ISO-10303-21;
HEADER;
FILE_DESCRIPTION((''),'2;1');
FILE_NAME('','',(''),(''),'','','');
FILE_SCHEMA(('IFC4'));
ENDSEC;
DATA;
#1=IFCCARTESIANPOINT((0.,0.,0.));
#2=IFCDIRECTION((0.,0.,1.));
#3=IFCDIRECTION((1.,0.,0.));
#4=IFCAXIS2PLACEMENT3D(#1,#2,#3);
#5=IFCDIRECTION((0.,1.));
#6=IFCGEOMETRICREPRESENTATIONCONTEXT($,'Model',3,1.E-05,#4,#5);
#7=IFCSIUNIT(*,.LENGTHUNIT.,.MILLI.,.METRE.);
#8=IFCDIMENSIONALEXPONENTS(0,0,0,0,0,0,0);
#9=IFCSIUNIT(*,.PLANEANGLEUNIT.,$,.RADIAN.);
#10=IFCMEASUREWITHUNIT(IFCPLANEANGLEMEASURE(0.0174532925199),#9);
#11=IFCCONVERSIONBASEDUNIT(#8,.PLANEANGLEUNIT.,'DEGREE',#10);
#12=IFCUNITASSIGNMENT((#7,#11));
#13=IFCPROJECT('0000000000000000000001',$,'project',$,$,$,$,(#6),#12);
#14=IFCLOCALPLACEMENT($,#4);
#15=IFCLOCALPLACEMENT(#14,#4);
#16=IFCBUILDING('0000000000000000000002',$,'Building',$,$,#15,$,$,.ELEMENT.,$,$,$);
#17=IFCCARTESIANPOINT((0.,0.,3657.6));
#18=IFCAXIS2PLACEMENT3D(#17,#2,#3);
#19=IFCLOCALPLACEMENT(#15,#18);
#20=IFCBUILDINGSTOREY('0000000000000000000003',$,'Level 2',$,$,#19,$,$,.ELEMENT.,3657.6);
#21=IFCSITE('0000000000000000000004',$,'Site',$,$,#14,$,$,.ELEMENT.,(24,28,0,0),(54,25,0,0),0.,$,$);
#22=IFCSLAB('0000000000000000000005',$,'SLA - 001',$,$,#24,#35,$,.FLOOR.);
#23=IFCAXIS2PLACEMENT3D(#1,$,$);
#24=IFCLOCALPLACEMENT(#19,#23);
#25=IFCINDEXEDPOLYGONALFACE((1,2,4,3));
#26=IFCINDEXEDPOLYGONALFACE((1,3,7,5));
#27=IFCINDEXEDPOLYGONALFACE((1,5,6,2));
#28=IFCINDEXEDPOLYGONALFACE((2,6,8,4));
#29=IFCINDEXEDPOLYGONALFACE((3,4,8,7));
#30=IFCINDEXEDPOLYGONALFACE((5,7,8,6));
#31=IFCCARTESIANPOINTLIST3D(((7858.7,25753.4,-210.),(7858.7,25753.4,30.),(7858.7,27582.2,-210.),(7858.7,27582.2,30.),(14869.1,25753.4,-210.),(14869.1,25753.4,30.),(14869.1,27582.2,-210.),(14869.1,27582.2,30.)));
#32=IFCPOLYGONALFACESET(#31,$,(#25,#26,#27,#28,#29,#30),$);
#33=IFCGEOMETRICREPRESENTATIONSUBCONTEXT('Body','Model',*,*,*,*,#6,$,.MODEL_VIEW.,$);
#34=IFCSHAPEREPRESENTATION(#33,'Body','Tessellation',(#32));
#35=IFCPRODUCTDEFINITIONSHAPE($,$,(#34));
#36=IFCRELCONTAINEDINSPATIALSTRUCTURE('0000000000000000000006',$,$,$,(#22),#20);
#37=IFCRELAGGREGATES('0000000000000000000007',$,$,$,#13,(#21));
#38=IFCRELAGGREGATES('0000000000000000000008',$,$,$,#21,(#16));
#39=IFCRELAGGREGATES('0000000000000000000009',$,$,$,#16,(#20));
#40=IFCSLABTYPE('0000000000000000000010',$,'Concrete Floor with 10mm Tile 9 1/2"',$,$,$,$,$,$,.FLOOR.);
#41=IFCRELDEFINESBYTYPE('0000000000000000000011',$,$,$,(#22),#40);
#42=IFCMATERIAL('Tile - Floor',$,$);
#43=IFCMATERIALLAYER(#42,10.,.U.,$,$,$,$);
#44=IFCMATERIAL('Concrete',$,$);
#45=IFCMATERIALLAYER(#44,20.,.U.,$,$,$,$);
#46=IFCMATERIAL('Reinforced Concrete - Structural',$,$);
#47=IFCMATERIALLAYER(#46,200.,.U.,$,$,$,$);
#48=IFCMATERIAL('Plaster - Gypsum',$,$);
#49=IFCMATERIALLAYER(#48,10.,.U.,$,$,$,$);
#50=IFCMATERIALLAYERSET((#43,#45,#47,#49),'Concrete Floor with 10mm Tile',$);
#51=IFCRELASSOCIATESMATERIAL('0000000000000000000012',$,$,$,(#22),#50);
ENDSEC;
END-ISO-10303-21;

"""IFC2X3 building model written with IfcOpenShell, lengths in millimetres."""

from ifc_helpers import new_model, entity, si_unit, converted_unit, direction, frame, origin_with_axes, place, context, subcontext, project, spatial, polyline, outline, extrude, material, layer, layer_set, layer_usage, type_object, element, save


model = new_model("IFC2X3")

# Units and contexts
model_context = context("Model", 3, precision=1e-05, world=origin_with_axes(), true_north=direction((0.0, 1.0)))
body_context = subcontext(model_context, "Body", "Model", "MODEL_VIEW")
ifc_project = project(units=[si_unit("LENGTHUNIT", "METRE", prefix="MILLI"), converted_unit("PLANEANGLEUNIT", "DEGREE", entity("IfcPlaneAngleMeasure", 0.0174532925199), si_unit("PLANEANGLEUNIT", "RADIAN"), dimensions=[0, 0, 0, 0, 0, 0, 0])], contexts=[model_context])

# Site, building, storey
site_placement = place(None, origin_with_axes())
site = spatial("IfcSite", under=ifc_project, at=site_placement, Name="Site", CompositionType="ELEMENT", RefLatitude=(24, 28, 0, 0), RefLongitude=(54, 25, 0, 0), RefElevation=0.0)
building_placement = place(site_placement, origin_with_axes())
building = spatial("IfcBuilding", under=site, at=building_placement, Name="Building", CompositionType="ELEMENT")
storey_placement = place(building_placement, frame((0.0, 0.0, 3657.6), z_axis=(0.0, 0.0, 1.0), x_axis=(1.0, 0.0, 0.0)))
storey = spatial("IfcBuildingStorey", under=building, at=storey_placement, Name="Level 2", CompositionType="ELEMENT", Elevation=3657.6)

# Slab
ifc_material_1 = material(Name="Tile - Floor")
ifc_layer_1 = layer(ifc_material_1, 10.0, ventilated="UNKNOWN")
ifc_material_2 = material(Name="Concrete")
ifc_layer_2 = layer(ifc_material_2, 20.0, ventilated="UNKNOWN")
ifc_material_3 = material(Name="Reinforced Concrete - Structural")
ifc_layer_3 = layer(ifc_material_3, 200.0, ventilated="UNKNOWN")
ifc_material_4 = material(Name="Plaster - Gypsum")
ifc_layer_4 = layer(ifc_material_4, 10.0, ventilated="UNKNOWN")
ifc_layer_set = layer_set([ifc_layer_1, ifc_layer_2, ifc_layer_3, ifc_layer_4], Name="Concrete Floor with 10mm Tile")
ifc_layer_usage = layer_usage(ifc_layer_set, "AXIS3", "NEGATIVE", 240.0)
slab_type = type_object("IfcSlabType", Name="Concrete Floor with 10mm Tile 9 1/2\"", PredefinedType="FLOOR")
slab_placement = place(storey_placement, frame((14869.1, 27582.2, 0.0), z_axis=(0.0, 0.0, 1.0), x_axis=(1.0, 0.0, 0.0)))
element("IfcSlab", 1, at=slab_placement, inside=storey, type_object=slab_type, material=ifc_layer_usage, Name="SLA - 001", PredefinedType="FLOOR", context=body_context, shape_type="SweptSolid", body=[
    extrude(outline(polyline([(0.0, 0.0), (-7010.4, 0.0), (-7010.4, -1828.8), (0.0, -1828.8), (0.0, 0.0)])), frame((0.0, 0.0, -210.0), z_axis=(0.0, 0.0, 1.0), x_axis=(1.0, 0.0, 0.0)), (0.0, 0.0, 1.0), 240.0),
])

save(model, "model.ifc")
